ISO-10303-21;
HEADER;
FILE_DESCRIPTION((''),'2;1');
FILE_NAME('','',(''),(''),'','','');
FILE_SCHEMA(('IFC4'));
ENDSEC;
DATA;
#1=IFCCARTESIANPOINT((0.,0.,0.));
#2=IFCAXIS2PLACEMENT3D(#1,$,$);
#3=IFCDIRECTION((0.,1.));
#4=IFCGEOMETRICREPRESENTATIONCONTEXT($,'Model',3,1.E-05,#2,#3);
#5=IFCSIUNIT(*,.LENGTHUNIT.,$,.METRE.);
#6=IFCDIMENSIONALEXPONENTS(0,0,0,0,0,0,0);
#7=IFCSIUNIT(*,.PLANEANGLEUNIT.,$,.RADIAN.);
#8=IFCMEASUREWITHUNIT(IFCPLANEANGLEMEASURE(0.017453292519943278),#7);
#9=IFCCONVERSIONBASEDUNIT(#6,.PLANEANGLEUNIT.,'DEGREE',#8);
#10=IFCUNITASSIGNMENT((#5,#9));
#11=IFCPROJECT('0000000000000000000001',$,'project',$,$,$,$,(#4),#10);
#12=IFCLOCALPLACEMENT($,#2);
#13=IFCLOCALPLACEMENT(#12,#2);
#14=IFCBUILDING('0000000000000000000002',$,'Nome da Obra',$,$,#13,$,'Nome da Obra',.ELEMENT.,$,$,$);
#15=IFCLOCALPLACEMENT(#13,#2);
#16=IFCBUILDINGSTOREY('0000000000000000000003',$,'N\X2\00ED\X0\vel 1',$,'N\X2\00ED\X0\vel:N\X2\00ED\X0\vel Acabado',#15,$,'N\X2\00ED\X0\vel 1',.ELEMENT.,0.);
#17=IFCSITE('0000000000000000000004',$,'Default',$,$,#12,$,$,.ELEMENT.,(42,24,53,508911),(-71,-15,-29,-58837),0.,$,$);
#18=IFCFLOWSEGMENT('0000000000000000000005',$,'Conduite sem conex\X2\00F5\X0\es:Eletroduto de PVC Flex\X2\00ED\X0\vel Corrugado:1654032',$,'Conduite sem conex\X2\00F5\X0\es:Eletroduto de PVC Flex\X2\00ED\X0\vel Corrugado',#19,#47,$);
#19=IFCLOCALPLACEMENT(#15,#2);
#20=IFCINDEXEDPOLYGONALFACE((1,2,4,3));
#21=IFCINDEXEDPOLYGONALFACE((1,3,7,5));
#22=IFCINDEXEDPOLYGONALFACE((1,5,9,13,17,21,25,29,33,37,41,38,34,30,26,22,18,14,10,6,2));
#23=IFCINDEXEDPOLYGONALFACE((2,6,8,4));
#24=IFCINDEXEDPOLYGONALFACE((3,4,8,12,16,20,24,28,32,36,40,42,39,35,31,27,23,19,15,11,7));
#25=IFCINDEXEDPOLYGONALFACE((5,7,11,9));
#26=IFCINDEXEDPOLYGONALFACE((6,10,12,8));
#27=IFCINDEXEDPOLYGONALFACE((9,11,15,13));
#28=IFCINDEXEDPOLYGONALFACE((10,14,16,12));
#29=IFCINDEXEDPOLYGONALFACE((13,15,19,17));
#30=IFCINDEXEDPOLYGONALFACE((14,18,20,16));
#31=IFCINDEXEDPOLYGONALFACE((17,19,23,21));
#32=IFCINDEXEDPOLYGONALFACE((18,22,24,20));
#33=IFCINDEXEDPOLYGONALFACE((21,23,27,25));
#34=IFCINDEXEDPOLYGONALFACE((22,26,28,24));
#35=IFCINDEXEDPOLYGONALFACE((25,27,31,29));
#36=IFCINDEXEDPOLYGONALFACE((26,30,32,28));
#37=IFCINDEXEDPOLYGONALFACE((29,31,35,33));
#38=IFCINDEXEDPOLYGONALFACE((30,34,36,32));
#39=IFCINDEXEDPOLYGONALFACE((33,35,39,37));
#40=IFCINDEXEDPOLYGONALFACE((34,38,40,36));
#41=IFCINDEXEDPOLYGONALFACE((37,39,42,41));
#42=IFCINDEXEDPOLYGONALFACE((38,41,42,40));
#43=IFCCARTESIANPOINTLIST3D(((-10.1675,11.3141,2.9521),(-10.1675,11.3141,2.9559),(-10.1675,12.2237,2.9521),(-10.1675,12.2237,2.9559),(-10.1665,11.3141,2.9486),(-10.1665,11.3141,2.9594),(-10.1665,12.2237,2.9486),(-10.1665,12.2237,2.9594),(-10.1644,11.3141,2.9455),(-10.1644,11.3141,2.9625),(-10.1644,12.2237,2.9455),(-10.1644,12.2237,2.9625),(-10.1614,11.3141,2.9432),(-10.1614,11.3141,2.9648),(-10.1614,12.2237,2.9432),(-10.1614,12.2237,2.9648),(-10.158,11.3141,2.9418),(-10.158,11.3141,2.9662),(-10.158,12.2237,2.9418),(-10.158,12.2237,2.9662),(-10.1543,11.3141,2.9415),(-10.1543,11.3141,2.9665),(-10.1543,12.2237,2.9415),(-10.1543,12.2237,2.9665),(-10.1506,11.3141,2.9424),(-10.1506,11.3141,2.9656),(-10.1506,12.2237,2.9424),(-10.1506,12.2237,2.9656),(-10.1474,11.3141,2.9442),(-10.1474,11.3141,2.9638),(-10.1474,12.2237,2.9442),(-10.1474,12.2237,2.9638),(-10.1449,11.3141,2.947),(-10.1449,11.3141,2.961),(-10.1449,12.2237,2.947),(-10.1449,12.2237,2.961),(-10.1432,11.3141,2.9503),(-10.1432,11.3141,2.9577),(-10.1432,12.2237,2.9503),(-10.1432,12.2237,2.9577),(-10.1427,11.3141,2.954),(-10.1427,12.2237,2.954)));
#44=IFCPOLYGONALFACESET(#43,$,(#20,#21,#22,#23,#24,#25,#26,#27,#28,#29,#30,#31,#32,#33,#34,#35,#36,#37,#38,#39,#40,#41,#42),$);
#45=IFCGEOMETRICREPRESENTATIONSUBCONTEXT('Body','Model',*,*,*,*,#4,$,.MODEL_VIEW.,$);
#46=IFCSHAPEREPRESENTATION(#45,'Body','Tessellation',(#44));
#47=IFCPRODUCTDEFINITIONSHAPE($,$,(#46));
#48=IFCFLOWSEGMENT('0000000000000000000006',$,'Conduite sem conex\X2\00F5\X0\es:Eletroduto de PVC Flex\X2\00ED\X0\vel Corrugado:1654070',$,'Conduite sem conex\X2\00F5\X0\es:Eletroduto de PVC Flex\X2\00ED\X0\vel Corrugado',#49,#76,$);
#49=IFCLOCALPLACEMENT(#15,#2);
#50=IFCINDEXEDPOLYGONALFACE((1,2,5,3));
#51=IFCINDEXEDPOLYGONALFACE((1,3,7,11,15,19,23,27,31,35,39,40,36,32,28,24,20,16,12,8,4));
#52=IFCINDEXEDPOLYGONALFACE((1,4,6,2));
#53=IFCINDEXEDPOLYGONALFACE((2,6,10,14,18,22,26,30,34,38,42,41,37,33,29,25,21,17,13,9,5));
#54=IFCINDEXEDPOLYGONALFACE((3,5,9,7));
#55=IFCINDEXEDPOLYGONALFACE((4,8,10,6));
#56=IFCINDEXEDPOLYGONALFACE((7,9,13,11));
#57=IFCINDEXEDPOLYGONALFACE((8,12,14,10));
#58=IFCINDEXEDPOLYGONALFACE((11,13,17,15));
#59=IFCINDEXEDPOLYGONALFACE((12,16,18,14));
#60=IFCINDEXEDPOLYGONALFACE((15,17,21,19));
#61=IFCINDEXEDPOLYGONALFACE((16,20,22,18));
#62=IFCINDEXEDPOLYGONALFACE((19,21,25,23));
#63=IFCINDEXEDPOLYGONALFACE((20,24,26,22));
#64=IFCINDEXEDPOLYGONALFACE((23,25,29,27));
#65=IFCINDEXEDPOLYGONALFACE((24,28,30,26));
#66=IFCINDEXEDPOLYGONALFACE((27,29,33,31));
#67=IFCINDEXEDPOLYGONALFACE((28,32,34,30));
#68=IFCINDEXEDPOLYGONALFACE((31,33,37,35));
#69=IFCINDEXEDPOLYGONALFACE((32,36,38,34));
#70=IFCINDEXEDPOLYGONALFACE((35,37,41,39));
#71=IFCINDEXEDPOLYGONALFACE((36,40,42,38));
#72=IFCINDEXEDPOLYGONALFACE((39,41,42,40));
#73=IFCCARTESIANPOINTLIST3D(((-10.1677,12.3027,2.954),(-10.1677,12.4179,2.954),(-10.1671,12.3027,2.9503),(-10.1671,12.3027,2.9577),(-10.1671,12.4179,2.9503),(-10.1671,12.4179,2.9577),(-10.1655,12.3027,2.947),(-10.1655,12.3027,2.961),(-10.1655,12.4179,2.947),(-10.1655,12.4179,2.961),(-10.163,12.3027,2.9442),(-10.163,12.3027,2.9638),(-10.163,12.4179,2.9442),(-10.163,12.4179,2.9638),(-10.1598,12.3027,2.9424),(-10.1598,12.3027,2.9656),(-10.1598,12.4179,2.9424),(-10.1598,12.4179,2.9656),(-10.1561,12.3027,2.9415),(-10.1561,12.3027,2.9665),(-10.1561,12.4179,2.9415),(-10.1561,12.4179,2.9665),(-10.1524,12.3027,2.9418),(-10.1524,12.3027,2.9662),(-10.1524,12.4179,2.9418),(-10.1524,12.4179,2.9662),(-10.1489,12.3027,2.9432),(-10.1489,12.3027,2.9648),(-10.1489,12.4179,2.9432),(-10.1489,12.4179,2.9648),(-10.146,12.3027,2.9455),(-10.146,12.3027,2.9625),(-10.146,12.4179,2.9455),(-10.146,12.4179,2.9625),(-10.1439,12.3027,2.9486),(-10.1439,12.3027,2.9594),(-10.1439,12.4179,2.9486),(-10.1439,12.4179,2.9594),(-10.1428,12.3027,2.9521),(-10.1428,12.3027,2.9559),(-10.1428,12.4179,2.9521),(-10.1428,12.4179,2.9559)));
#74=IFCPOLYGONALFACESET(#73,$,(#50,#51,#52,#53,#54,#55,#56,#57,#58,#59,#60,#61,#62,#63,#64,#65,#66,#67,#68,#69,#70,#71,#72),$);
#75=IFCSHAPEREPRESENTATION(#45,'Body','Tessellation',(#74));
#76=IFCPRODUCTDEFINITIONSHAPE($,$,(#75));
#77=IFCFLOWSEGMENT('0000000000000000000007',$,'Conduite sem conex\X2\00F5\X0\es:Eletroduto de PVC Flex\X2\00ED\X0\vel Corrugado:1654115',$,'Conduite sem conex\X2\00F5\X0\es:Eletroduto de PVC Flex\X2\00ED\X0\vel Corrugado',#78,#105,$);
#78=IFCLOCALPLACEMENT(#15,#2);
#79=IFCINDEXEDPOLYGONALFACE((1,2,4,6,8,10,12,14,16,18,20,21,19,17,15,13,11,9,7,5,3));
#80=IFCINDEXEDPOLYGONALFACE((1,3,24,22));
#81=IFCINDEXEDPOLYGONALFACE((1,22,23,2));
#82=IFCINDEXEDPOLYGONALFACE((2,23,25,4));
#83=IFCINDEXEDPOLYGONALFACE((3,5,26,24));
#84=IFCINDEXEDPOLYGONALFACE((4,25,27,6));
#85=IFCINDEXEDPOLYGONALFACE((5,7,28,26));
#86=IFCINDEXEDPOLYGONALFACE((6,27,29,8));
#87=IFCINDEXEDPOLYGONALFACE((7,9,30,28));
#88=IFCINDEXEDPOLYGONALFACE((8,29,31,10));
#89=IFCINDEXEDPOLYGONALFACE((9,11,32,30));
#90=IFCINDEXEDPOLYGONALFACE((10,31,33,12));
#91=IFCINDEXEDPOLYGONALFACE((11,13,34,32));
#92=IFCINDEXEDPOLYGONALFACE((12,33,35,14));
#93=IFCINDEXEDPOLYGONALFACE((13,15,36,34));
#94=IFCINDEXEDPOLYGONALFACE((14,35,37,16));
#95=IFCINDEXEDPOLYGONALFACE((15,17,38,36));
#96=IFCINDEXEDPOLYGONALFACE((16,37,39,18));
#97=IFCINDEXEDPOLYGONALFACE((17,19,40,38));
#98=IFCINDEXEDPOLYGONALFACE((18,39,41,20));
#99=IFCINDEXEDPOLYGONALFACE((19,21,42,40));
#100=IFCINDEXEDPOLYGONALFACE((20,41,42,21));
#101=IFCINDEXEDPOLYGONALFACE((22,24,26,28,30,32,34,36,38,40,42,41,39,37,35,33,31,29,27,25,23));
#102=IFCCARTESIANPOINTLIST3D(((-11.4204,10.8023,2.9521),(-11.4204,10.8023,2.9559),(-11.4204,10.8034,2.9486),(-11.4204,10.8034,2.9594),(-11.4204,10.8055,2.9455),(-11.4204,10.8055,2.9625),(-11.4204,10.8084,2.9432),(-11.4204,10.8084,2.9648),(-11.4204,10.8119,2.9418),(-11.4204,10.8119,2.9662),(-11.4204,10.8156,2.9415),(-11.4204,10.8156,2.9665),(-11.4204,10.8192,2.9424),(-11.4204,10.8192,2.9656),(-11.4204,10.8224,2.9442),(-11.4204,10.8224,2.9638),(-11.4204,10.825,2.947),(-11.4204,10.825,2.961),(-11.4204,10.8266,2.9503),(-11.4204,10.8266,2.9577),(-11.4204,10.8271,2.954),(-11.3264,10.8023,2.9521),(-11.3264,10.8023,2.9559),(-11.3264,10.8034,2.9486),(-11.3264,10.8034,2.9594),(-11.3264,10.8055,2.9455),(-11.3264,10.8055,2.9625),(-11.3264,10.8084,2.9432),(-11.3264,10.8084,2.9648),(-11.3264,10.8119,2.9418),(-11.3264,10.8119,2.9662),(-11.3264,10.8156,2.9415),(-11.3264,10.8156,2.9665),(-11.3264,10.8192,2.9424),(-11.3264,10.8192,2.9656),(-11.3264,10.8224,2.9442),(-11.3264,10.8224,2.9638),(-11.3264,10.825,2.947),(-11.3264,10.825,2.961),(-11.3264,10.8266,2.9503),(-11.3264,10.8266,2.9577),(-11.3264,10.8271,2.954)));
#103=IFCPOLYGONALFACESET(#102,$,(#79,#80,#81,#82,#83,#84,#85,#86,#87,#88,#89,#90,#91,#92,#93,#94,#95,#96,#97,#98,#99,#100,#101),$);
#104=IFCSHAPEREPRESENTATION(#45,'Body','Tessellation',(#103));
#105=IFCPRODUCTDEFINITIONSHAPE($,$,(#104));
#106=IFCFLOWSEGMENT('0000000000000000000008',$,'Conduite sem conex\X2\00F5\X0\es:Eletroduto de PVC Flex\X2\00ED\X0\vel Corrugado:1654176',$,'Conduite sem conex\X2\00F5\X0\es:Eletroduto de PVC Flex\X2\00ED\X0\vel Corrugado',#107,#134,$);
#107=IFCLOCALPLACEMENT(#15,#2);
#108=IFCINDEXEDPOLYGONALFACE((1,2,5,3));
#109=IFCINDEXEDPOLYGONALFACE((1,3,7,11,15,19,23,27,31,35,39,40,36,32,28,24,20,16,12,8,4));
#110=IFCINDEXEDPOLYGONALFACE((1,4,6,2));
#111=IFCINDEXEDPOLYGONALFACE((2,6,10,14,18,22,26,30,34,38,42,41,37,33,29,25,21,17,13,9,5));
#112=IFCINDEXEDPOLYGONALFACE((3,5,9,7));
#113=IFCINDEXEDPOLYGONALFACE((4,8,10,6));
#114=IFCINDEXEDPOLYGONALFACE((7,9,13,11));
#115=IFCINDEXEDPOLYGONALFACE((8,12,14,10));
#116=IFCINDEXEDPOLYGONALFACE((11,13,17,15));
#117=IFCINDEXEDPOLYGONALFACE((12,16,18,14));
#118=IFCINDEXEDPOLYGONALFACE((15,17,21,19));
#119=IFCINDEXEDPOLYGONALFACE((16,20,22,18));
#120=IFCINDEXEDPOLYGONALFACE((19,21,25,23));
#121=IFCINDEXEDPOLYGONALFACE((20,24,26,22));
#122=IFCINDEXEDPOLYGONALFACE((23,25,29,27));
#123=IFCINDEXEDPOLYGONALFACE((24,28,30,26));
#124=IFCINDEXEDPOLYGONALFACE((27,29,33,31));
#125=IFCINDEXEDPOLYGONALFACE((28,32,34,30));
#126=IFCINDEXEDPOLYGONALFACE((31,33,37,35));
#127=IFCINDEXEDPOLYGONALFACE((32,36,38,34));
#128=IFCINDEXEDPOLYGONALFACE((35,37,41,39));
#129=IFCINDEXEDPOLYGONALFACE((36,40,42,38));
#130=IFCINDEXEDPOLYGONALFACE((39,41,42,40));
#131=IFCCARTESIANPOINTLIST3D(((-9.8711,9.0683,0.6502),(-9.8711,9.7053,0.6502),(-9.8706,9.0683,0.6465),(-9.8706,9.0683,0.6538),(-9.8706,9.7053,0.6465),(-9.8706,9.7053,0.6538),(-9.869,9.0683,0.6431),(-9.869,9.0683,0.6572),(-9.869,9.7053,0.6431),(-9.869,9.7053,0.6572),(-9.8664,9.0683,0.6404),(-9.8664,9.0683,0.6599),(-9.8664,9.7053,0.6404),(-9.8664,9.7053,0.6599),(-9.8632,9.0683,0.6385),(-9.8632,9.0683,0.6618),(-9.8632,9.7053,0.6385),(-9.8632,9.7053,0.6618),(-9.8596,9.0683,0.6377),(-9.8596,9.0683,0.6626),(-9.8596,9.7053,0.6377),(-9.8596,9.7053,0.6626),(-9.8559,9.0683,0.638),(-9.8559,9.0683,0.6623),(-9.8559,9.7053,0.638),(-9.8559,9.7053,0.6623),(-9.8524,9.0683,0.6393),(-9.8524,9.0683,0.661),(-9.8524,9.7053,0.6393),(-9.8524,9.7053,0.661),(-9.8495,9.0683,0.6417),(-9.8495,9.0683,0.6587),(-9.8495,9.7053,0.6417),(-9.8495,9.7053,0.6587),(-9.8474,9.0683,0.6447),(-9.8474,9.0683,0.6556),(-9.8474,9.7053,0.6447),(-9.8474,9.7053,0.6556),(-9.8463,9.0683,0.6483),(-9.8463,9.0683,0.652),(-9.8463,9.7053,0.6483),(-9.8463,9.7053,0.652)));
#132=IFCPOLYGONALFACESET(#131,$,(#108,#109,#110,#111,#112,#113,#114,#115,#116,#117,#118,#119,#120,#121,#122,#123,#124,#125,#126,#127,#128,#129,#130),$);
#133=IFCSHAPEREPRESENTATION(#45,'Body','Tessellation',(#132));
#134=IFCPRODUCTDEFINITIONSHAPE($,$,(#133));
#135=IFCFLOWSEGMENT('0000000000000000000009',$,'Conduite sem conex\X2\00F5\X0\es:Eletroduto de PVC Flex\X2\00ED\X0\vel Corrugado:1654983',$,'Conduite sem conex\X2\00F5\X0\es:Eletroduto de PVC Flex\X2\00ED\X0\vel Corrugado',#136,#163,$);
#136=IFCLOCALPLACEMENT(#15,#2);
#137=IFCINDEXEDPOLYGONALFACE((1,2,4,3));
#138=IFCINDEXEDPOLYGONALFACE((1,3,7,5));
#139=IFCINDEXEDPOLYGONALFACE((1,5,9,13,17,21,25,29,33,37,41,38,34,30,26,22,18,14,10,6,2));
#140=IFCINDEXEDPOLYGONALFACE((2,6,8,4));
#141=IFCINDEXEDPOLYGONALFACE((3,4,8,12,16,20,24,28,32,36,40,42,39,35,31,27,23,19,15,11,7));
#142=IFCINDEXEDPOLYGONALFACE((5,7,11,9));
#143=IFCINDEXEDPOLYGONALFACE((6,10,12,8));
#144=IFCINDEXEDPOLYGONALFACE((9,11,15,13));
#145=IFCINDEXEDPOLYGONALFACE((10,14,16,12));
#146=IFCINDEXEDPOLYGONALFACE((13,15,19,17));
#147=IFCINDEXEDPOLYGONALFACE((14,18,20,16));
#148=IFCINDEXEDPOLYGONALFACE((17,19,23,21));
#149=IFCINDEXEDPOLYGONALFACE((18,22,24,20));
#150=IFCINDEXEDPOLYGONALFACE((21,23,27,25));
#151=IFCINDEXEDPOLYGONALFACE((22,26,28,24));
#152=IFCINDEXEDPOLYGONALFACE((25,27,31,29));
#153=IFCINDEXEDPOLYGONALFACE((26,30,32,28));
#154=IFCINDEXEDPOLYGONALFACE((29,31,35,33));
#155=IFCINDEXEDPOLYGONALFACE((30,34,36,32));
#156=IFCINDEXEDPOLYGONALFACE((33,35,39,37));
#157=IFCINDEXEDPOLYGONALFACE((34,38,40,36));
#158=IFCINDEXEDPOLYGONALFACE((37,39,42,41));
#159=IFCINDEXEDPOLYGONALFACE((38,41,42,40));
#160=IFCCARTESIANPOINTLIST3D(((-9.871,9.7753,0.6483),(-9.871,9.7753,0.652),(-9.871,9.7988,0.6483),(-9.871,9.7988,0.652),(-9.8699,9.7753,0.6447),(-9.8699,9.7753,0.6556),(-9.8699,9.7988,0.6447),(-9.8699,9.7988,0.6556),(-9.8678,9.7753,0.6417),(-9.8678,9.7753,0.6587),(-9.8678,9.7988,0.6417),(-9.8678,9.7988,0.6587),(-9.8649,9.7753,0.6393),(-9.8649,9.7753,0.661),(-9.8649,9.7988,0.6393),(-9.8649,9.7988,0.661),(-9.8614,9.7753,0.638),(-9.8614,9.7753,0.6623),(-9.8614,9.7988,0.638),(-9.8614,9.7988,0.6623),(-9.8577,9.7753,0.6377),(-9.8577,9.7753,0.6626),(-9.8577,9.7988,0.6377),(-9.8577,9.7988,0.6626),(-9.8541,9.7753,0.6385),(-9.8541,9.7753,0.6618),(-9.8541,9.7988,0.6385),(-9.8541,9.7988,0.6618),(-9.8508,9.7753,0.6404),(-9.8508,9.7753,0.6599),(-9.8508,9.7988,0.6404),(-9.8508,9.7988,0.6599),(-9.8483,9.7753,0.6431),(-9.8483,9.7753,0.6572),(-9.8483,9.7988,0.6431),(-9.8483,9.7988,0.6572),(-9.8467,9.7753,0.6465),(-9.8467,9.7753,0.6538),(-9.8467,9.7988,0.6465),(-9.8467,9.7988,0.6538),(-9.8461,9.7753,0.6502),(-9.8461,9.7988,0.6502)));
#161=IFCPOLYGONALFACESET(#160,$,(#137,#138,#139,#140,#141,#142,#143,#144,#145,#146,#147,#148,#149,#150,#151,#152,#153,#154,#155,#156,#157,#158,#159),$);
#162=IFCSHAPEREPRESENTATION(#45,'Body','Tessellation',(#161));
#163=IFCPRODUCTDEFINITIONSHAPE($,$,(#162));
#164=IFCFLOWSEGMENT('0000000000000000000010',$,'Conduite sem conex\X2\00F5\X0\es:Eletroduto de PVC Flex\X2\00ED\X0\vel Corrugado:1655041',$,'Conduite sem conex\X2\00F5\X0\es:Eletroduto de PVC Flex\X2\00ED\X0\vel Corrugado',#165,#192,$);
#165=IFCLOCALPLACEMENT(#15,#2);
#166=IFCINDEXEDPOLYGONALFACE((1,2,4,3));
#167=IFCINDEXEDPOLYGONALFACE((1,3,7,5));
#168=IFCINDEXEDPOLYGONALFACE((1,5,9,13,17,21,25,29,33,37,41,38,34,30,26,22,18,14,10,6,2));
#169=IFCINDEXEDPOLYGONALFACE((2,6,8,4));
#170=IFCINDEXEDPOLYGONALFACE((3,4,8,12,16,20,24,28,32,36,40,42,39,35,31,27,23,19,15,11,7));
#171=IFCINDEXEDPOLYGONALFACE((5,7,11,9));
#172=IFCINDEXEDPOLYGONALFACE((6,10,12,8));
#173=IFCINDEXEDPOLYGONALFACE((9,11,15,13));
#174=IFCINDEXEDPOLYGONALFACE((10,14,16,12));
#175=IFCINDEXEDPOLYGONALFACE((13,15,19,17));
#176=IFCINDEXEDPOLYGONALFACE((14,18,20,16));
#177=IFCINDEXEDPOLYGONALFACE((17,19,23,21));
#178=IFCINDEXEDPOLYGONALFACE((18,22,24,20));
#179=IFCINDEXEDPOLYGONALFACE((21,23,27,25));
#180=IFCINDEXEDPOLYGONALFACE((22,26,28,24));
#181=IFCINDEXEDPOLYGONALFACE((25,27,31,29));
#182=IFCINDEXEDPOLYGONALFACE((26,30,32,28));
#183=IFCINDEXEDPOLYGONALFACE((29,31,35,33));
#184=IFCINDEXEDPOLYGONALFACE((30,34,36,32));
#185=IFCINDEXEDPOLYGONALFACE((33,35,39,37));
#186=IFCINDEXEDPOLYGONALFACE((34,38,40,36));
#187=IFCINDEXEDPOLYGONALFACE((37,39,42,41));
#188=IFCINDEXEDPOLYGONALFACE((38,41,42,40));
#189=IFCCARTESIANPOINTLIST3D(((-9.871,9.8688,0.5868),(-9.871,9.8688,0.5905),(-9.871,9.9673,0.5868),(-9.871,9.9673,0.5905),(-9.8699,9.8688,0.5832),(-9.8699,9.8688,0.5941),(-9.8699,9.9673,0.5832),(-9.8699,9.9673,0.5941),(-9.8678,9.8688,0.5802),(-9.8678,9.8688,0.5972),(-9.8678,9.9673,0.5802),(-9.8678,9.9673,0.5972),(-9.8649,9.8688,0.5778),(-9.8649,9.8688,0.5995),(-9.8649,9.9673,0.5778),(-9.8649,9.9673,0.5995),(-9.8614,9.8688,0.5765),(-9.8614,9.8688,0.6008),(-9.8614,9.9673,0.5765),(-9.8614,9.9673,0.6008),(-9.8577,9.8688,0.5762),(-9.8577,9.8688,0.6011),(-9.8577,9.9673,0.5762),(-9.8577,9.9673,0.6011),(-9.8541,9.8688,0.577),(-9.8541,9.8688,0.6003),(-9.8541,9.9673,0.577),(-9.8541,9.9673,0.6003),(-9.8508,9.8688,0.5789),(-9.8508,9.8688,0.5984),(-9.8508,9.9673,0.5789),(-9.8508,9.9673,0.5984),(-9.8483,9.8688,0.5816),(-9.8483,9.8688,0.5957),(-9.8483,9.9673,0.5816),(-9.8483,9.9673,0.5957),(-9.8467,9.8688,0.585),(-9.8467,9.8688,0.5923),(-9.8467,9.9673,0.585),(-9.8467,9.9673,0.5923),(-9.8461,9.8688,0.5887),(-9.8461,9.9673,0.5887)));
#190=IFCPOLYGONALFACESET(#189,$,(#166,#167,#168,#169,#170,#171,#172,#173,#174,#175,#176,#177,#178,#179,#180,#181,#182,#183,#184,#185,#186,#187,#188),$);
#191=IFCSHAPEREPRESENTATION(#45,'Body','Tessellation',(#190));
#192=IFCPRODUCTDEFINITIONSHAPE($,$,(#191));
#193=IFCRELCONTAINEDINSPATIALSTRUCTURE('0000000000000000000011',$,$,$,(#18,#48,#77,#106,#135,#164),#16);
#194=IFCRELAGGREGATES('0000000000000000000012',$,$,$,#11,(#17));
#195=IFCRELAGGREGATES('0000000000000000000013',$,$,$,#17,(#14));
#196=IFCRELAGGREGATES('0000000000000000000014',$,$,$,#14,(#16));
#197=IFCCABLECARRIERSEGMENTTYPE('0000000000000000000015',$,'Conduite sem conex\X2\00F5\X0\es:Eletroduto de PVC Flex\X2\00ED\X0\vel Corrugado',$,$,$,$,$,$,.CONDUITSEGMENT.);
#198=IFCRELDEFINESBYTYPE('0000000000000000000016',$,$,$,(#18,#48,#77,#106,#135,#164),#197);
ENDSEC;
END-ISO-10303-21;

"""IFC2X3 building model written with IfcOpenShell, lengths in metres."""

from ifc_helpers import new_model, entity, si_unit, converted_unit, direction, frame, frame_2d, origin, origin_2d_with_axis, place, context, subcontext, project, spatial, circle, extrude, type_object, element, save


model = new_model("IFC2X3")

# Units and contexts
model_context = context("Model", 3, precision=1e-05, world=origin(), true_north=direction((0.0, 1.0)))
body_context = subcontext(model_context, "Body", "Model", "MODEL_VIEW")
ifc_project = project(units=[si_unit("LENGTHUNIT", "METRE"), converted_unit("PLANEANGLEUNIT", "DEGREE", entity("IfcPlaneAngleMeasure", 0.017453292519943278), si_unit("PLANEANGLEUNIT", "RADIAN"), dimensions=[0, 0, 0, 0, 0, 0, 0])], contexts=[model_context])

# Site, building, storey
site_placement = place(None, origin())
site = spatial("IfcSite", under=ifc_project, at=site_placement, Name="Default", CompositionType="ELEMENT", RefLatitude=(42, 24, 53, 508911), RefLongitude=(-71, -15, -29, -58837), RefElevation=0.0)
building_placement = place(site_placement, origin())
building = spatial("IfcBuilding", under=site, at=building_placement, Name="Nome da Obra", LongName="Nome da Obra", CompositionType="ELEMENT")
storey_placement = place(building_placement, origin())
storey = spatial("IfcBuildingStorey", under=building, at=storey_placement, Name="Nível 1", ObjectType="Nível:Nível Acabado", LongName="Nível 1", CompositionType="ELEMENT", Elevation=0.0)

# Flow segments
cable_carrier_segment_type = type_object("IfcCableCarrierSegmentType", Name="Conduite sem conexões:Eletroduto de PVC Flexível Corrugado", PredefinedType="CONDUITSEGMENT")
flow_segment_1_placement = place(storey_placement, origin())
element("IfcFlowSegment", 1, at=flow_segment_1_placement, inside=storey, type_object=cable_carrier_segment_type, Name="Conduite sem conexões:Eletroduto de PVC Flexível Corrugado:1654032", ObjectType="Conduite sem conexões:Eletroduto de PVC Flexível Corrugado", context=body_context, shape_type="SweptSolid", body=[
    extrude(circle(Radius=0.0125, at=frame_2d((0.0, 0.0), x_axis=(1.0, 0.0))), frame((-10.1552, 11.3141, 2.954), z_axis=(0.0, 1.0, 0.0), x_axis=(1.0, 0.0, 0.0)), (0.0, 0.0, 1.0), 0.9096),
])
flow_segment_2_placement = place(storey_placement, origin())
element("IfcFlowSegment", 2, at=flow_segment_2_placement, inside=storey, type_object=cable_carrier_segment_type, Name="Conduite sem conexões:Eletroduto de PVC Flexível Corrugado:1654070", ObjectType="Conduite sem conexões:Eletroduto de PVC Flexível Corrugado", context=body_context, shape_type="SweptSolid", body=[
    extrude(circle(Radius=0.0125, at=origin_2d_with_axis()), frame((-10.1552, 12.3027, 2.954), z_axis=(0.0, 1.0, 0.0), x_axis=(-1.0, 0.0, 0.0)), (0.0, 0.0, 1.0), 0.1151),
])
flow_segment_3_placement = place(storey_placement, origin())
element("IfcFlowSegment", 3, at=flow_segment_3_placement, inside=storey, type_object=cable_carrier_segment_type, Name="Conduite sem conexões:Eletroduto de PVC Flexível Corrugado:1654115", ObjectType="Conduite sem conexões:Eletroduto de PVC Flexível Corrugado", context=body_context, shape_type="SweptSolid", body=[
    extrude(circle(Radius=0.0125, at=frame_2d((0.0, 0.0), x_axis=(1.0, 0.0))), frame((-11.4204, 10.8146, 2.954), z_axis=(1.0, 0.0, 0.0), x_axis=(0.0, 1.0, 0.0)), (0.0, 0.0, 1.0), 0.094),
])
flow_segment_4_placement = place(storey_placement, origin())
element("IfcFlowSegment", 4, at=flow_segment_4_placement, inside=storey, type_object=cable_carrier_segment_type, Name="Conduite sem conexões:Eletroduto de PVC Flexível Corrugado:1654176", ObjectType="Conduite sem conexões:Eletroduto de PVC Flexível Corrugado", context=body_context, shape_type="SweptSolid", body=[
    extrude(circle(Radius=0.0125, at=frame_2d((0.0, 0.0), x_axis=(1.0, 0.0))), frame((-9.8586, 9.0683, 0.6502), z_axis=(0.0, 1.0, 0.0), x_axis=(-1.0, 0.0, 0.0)), (0.0, 0.0, 1.0), 0.637),
])
flow_segment_5_placement = place(storey_placement, origin())
element("IfcFlowSegment", 5, at=flow_segment_5_placement, inside=storey, type_object=cable_carrier_segment_type, Name="Conduite sem conexões:Eletroduto de PVC Flexível Corrugado:1654983", ObjectType="Conduite sem conexões:Eletroduto de PVC Flexível Corrugado", context=body_context, shape_type="SweptSolid", body=[
    extrude(circle(Radius=0.0125, at=origin_2d_with_axis()), frame((-9.8586, 9.7753, 0.6502), z_axis=(0.0, 1.0, 0.0), x_axis=(1.0, 0.0, 0.0)), (0.0, 0.0, 1.0), 0.0235),
])
flow_segment_6_placement = place(storey_placement, origin())
element("IfcFlowSegment", 6, at=flow_segment_6_placement, inside=storey, type_object=cable_carrier_segment_type, Name="Conduite sem conexões:Eletroduto de PVC Flexível Corrugado:1655041", ObjectType="Conduite sem conexões:Eletroduto de PVC Flexível Corrugado", context=body_context, shape_type="SweptSolid", body=[
    extrude(circle(Radius=0.0125, at=origin_2d_with_axis()), frame((-9.8586, 9.8688, 0.5887), z_axis=(0.0, 1.0, 0.0), x_axis=(1.0, 0.0, 0.0)), (0.0, 0.0, 1.0), 0.0985),
])

save(model, "model.ifc")
